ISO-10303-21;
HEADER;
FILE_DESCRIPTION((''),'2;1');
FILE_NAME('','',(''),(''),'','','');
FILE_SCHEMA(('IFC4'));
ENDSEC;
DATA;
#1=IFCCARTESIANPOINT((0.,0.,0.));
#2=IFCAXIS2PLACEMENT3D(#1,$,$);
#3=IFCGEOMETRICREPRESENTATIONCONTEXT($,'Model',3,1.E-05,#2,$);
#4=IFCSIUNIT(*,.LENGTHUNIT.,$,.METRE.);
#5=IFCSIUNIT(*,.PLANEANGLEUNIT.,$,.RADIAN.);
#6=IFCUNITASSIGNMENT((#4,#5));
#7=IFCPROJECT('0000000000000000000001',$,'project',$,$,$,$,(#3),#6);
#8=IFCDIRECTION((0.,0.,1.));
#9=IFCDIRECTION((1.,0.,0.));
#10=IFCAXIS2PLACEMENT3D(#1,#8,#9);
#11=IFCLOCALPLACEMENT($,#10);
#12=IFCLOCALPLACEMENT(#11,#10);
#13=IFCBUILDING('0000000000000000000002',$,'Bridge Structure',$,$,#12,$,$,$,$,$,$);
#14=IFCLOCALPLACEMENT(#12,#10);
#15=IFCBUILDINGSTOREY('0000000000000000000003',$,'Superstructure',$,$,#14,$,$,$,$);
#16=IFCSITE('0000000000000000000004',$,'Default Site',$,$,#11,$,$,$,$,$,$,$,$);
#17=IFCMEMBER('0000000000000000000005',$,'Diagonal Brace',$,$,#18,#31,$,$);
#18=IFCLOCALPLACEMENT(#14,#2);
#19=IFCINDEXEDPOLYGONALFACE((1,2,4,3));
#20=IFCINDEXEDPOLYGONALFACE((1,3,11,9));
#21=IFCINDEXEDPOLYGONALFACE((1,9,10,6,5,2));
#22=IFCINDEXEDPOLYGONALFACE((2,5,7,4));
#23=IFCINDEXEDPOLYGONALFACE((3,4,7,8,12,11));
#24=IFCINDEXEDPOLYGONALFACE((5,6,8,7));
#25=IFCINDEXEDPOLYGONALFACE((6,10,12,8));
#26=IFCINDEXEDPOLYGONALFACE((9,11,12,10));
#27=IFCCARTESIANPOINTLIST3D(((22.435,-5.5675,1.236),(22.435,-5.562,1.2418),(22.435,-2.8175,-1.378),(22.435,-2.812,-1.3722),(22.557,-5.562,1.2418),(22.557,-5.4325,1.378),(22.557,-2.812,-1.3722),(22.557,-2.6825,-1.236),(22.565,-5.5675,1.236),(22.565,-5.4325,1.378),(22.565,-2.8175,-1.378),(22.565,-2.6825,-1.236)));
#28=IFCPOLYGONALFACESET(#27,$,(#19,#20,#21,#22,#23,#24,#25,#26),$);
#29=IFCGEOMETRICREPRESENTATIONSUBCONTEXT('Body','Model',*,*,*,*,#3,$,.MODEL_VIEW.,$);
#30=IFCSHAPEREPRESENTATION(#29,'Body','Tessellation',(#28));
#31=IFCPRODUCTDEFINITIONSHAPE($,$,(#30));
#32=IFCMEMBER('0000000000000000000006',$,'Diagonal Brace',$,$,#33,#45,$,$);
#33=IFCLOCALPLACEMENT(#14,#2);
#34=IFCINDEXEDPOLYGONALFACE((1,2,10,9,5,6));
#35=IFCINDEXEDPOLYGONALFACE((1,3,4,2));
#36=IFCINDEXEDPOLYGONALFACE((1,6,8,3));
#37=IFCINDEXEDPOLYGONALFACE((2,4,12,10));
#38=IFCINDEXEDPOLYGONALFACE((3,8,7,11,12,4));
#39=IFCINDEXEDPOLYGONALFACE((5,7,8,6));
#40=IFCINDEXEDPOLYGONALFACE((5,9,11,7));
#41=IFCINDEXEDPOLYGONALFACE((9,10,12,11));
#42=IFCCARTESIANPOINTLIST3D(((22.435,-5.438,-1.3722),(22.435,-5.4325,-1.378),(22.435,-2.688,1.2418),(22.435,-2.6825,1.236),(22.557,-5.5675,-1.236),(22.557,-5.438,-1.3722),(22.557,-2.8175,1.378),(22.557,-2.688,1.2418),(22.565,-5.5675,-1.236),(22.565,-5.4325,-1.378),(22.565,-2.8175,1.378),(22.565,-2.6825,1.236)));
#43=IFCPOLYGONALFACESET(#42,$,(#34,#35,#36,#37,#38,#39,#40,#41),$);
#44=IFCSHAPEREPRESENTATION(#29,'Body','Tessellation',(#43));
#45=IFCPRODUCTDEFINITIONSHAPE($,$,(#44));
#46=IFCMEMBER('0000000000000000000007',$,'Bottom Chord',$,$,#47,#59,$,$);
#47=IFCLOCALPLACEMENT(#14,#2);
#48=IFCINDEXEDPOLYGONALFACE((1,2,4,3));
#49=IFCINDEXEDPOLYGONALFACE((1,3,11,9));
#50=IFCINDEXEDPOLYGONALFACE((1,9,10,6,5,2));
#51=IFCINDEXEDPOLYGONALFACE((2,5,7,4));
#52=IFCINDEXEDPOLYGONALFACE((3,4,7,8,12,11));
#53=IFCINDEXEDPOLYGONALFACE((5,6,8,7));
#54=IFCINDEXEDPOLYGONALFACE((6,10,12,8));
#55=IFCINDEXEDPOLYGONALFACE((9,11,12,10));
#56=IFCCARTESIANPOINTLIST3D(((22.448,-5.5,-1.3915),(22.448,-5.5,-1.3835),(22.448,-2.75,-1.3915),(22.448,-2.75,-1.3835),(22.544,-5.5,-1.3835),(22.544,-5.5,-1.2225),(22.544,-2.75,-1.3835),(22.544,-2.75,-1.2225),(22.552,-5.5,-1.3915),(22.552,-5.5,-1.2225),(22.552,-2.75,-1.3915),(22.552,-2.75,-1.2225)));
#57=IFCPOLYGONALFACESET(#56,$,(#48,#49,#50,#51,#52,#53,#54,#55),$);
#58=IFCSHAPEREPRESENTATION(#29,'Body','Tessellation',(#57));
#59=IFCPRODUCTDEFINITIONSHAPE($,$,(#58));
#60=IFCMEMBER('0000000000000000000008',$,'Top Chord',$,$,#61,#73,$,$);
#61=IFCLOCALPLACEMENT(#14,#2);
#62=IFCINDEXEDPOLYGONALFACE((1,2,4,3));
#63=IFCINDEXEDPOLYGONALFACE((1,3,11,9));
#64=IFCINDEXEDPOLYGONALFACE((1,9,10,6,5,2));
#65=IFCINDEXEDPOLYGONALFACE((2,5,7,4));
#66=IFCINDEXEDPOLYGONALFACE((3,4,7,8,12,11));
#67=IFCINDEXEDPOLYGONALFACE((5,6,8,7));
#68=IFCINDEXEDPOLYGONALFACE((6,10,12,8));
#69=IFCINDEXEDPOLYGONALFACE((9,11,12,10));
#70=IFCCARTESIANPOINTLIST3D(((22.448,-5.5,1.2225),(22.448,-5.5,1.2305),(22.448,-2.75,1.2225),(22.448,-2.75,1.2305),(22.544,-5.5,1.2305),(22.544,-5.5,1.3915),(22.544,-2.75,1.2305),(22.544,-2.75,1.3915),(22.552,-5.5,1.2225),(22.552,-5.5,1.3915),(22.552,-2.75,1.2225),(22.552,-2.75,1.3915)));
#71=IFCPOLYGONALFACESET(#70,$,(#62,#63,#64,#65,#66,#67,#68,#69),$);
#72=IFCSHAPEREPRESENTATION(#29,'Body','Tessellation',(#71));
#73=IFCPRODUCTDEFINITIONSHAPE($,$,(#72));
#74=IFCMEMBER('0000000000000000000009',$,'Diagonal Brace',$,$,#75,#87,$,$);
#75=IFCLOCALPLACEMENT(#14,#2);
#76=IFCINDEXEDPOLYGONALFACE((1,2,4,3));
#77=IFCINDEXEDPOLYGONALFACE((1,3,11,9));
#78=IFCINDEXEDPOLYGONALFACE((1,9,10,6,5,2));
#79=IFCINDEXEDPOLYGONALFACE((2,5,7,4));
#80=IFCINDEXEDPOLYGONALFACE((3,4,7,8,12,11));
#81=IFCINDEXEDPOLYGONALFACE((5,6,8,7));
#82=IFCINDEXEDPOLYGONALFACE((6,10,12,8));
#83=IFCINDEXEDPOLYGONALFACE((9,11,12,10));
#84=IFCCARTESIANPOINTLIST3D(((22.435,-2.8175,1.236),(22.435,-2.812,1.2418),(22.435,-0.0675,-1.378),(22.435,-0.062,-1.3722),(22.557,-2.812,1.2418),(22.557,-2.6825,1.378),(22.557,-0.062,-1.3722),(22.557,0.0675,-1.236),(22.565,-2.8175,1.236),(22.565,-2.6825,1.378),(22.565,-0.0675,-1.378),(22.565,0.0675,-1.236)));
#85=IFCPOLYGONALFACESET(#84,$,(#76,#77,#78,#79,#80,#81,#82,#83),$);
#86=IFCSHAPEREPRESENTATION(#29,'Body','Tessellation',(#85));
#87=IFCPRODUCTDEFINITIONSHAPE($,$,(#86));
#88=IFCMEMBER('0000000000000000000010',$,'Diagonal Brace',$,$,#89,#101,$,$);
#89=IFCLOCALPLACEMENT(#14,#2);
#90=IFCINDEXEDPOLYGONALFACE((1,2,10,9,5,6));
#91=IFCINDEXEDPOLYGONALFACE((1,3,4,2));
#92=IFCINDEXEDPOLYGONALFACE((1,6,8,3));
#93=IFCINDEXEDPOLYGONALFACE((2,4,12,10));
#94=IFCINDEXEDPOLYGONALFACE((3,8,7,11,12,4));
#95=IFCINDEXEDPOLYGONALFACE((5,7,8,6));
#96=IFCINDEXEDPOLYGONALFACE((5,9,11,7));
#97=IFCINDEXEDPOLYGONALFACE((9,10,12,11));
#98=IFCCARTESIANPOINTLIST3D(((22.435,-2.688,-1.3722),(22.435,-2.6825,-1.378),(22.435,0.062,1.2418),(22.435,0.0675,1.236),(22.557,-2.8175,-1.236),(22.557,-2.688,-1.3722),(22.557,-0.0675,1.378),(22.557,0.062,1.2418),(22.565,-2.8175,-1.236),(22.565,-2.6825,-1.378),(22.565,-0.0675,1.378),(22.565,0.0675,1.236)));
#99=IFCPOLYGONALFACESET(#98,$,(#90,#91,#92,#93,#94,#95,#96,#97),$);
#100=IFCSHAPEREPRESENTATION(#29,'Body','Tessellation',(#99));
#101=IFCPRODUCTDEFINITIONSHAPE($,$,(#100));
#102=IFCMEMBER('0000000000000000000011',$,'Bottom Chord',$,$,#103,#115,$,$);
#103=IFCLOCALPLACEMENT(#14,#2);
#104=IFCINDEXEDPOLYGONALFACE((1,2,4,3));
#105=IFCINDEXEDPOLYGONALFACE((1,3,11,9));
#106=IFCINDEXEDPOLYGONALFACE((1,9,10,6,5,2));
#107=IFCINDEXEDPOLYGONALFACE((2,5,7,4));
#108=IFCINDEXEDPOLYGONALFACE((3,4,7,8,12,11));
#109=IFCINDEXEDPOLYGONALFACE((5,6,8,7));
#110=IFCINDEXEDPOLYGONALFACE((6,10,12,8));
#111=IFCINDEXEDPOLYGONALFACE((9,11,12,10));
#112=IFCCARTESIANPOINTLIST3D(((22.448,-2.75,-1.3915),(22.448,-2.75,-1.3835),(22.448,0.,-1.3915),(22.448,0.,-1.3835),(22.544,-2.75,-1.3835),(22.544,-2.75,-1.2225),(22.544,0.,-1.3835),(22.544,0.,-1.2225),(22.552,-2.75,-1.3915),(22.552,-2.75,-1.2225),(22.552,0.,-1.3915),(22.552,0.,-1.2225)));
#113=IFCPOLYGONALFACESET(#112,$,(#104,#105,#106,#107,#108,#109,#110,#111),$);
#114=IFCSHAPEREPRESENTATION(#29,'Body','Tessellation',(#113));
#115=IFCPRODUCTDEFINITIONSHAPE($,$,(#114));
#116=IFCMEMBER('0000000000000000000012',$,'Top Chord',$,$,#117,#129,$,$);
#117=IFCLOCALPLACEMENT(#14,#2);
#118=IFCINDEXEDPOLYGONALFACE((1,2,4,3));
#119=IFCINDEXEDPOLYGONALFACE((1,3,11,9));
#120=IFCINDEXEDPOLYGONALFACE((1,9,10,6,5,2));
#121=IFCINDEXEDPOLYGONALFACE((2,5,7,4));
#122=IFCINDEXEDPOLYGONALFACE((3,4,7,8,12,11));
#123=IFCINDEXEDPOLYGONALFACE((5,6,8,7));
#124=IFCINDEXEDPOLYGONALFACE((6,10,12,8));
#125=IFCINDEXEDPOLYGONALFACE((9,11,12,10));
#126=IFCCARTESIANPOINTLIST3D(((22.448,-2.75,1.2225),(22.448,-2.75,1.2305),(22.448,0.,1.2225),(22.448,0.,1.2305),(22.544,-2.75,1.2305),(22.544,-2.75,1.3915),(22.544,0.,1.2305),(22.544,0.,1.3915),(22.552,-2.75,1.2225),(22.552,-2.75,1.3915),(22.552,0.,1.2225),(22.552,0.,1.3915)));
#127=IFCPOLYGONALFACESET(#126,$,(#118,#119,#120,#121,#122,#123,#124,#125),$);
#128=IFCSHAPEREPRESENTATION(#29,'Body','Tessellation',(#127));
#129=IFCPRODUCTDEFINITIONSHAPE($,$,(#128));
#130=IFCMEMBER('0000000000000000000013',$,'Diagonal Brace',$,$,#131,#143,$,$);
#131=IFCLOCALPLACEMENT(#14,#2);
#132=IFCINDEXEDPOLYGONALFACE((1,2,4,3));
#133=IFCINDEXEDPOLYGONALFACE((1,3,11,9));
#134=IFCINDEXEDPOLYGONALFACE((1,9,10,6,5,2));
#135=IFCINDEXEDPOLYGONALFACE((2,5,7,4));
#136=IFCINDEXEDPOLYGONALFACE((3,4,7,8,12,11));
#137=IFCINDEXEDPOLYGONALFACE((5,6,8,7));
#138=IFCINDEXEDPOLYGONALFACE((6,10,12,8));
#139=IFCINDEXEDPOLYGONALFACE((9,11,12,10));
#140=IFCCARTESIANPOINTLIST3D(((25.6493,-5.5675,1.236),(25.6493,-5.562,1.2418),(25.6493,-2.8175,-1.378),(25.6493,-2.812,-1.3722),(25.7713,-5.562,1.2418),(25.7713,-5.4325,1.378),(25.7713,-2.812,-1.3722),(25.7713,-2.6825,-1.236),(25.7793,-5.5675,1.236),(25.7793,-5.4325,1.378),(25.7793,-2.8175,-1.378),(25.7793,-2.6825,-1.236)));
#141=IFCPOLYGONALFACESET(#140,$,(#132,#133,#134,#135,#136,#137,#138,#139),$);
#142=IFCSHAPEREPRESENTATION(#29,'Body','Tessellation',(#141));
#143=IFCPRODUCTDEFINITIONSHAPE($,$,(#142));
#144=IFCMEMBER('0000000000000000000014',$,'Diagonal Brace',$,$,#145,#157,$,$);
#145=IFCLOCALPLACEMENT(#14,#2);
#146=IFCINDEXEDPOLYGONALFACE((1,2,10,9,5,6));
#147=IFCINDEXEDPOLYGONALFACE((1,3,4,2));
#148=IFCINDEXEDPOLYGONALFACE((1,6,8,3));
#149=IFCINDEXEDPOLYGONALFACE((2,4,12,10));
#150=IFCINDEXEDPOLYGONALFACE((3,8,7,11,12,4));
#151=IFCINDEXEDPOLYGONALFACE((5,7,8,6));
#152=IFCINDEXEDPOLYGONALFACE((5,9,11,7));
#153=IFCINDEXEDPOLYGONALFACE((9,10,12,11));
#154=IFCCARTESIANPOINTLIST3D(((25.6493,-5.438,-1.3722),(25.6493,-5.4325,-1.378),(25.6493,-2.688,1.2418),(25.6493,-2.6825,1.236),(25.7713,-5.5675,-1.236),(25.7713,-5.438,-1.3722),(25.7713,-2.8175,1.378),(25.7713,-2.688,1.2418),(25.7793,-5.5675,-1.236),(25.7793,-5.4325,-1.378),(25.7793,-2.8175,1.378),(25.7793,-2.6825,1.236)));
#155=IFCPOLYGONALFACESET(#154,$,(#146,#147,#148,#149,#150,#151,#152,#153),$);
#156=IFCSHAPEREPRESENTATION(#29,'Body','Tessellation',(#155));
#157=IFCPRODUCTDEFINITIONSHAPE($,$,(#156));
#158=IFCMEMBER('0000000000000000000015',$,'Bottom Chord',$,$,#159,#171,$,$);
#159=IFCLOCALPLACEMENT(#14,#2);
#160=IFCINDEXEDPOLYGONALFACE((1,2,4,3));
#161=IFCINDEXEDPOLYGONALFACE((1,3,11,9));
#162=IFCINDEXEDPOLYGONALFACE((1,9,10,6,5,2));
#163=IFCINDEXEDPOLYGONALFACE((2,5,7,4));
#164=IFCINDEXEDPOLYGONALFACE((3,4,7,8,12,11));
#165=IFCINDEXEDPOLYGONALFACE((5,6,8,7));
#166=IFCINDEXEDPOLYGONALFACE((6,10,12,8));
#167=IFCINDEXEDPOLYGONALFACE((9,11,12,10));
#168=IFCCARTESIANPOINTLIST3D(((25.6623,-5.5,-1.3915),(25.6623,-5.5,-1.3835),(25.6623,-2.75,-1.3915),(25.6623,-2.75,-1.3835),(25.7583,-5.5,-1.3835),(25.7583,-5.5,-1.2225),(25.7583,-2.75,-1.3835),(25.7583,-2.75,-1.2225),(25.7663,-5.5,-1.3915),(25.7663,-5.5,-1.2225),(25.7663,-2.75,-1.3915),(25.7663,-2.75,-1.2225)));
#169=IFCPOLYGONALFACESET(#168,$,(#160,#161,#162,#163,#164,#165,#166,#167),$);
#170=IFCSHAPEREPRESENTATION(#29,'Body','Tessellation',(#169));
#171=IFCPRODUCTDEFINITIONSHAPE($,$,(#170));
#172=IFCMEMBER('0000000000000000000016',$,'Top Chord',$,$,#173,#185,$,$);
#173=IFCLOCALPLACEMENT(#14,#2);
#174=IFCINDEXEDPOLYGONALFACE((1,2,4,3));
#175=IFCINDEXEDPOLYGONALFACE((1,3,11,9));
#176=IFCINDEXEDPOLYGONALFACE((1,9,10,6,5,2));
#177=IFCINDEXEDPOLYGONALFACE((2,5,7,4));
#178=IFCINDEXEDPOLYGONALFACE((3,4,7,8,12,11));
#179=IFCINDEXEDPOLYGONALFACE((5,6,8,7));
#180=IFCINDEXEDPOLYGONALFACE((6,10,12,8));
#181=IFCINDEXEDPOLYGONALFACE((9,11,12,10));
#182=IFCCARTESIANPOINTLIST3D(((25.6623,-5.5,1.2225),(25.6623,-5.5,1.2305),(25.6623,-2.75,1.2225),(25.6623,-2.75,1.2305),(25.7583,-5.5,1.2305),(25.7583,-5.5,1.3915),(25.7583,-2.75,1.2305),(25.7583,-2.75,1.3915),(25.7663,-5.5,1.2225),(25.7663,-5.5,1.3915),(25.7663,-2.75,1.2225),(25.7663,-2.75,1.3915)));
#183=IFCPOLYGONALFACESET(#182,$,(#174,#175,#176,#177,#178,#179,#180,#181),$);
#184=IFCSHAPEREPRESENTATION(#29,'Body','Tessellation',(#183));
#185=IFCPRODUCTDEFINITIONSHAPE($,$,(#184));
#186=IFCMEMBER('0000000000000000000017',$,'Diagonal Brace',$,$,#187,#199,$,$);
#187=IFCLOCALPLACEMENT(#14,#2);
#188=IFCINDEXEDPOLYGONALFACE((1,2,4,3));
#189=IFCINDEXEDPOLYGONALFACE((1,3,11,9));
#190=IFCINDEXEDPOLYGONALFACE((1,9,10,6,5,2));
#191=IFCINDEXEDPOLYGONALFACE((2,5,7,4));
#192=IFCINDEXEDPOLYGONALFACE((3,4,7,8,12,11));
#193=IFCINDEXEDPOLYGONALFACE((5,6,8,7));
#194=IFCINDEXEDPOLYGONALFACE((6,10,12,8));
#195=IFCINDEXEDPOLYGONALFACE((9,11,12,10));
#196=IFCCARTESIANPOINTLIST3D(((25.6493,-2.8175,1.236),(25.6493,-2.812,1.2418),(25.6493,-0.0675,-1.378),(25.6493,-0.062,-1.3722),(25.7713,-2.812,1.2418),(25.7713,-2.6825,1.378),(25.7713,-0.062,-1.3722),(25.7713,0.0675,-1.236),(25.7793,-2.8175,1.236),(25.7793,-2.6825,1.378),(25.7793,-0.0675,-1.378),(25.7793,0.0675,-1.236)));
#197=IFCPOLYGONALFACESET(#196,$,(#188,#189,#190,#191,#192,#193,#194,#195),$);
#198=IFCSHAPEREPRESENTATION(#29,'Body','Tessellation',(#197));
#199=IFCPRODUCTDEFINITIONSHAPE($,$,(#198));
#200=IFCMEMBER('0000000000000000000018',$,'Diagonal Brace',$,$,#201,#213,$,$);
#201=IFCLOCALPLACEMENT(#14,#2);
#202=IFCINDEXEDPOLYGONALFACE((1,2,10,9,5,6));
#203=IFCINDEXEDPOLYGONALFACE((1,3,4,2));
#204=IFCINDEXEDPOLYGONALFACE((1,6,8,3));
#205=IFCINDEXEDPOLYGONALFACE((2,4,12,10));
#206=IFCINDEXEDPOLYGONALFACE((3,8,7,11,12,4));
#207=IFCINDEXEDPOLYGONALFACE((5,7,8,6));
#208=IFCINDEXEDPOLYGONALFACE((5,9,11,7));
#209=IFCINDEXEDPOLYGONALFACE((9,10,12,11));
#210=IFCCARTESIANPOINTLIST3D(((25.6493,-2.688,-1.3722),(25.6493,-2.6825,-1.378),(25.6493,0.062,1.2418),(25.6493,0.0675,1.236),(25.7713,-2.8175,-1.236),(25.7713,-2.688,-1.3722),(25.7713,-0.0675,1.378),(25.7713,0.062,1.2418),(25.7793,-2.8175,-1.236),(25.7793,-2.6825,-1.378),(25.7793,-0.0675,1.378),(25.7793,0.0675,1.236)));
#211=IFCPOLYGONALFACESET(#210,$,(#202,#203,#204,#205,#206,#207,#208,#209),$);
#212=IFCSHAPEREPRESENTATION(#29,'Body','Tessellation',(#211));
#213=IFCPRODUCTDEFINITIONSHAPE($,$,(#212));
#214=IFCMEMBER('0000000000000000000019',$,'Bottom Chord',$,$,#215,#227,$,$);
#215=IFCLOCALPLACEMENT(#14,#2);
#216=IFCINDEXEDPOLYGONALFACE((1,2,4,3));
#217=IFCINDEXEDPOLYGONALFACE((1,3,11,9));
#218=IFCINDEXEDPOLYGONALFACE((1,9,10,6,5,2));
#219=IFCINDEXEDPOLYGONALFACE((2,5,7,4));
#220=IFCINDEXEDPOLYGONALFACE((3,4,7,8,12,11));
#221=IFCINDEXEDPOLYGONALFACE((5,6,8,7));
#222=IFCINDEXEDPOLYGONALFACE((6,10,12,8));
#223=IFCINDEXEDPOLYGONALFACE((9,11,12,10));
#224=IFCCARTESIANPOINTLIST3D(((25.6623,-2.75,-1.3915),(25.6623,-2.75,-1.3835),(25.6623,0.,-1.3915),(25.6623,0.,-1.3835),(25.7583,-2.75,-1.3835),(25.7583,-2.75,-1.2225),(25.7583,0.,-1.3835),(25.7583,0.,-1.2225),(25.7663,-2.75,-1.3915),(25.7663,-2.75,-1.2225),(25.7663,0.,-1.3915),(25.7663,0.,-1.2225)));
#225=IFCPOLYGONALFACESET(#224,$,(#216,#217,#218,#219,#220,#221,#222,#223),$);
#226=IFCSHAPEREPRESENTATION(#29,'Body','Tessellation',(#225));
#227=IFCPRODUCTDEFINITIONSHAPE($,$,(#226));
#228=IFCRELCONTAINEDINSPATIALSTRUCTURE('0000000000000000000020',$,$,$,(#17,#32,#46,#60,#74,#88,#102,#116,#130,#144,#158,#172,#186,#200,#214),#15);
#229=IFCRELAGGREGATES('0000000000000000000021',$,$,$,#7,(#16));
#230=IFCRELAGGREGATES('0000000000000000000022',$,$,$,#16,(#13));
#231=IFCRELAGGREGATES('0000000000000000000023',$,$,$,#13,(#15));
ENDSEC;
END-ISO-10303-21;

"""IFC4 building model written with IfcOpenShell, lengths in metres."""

from ifc_helpers import new_model, si_unit, frame, origin, origin_with_axes, origin_2d_with_axis, place, context, subcontext, project, spatial, l_section, extrude, element, save


model = new_model("IFC4")

# Units and contexts
model_context = context("Model", 3, precision=1e-05, world=origin())
body_context = subcontext(model_context, "Body", "Model", "MODEL_VIEW")
ifc_project = project(units=[si_unit("LENGTHUNIT", "METRE"), si_unit("PLANEANGLEUNIT", "RADIAN")], contexts=[model_context])

# Site, building, storey
site_placement = place(None, origin_with_axes())
site = spatial("IfcSite", under=ifc_project, at=site_placement, Name="Default Site")
building_placement = place(site_placement, origin_with_axes())
building = spatial("IfcBuilding", under=site, at=building_placement, Name="Bridge Structure")
storey_placement = place(building_placement, origin_with_axes())
storey = spatial("IfcBuildingStorey", under=building, at=storey_placement, Name="Superstructure")

# Members
for number, where, z_axis, x_axis, name in (
    (1, (22.5, -5.5, 1.307), (0.0, 0.724802, -0.688957), (-1.0, 0.0, 0.0), "Diagonal Brace"),
    (2, (22.5, -5.5, -1.307), (0.0, 0.724802, 0.688957), (-1.0, 0.0, 0.0), "Diagonal Brace"),
):
    element("IfcMember", number, at=place(storey_placement, frame(where, z_axis=z_axis, x_axis=x_axis)), inside=storey, Name=name, context=body_context, shape_type="SweptSolid", body=[
        extrude(l_section(Depth=0.196, Width=0.13, Thickness=0.008, at=origin_2d_with_axis()), origin_with_axes(), (0.0, 0.0, 1.0), 3.7941),
    ])
for number, where, z_axis, x_axis, name in (
    (3, (22.5, -5.5, -1.307), (0.0, 1.0, 0.0), (-1.0, 0.0, 0.0), "Bottom Chord"),
    (4, (22.5, -5.5, 1.307), (0.0, 1.0, 0.0), (-1.0, 0.0, 0.0), "Top Chord"),
):
    element("IfcMember", number, at=place(storey_placement, frame(where, z_axis=z_axis, x_axis=x_axis)), inside=storey, Name=name, context=body_context, shape_type="SweptSolid", body=[
        extrude(l_section(Depth=0.169, Width=0.104, Thickness=0.008, at=origin_2d_with_axis()), origin_with_axes(), (0.0, 0.0, 1.0), 2.75),
    ])
for number, where, z_axis, x_axis, name in (
    (5, (22.5, -2.75, 1.307), (0.0, 0.724802, -0.688957), (-1.0, 0.0, 0.0), "Diagonal Brace"),
    (6, (22.5, -2.75, -1.307), (0.0, 0.724802, 0.688957), (-1.0, 0.0, 0.0), "Diagonal Brace"),
):
    element("IfcMember", number, at=place(storey_placement, frame(where, z_axis=z_axis, x_axis=x_axis)), inside=storey, Name=name, context=body_context, shape_type="SweptSolid", body=[
        extrude(l_section(Depth=0.196, Width=0.13, Thickness=0.008, at=origin_2d_with_axis()), origin_with_axes(), (0.0, 0.0, 1.0), 3.7941),
    ])
for number, where, z_axis, x_axis, name in (
    (7, (22.5, -2.75, -1.307), (0.0, 1.0, 0.0), (-1.0, 0.0, 0.0), "Bottom Chord"),
    (8, (22.5, -2.75, 1.307), (0.0, 1.0, 0.0), (-1.0, 0.0, 0.0), "Top Chord"),
):
    element("IfcMember", number, at=place(storey_placement, frame(where, z_axis=z_axis, x_axis=x_axis)), inside=storey, Name=name, context=body_context, shape_type="SweptSolid", body=[
        extrude(l_section(Depth=0.169, Width=0.104, Thickness=0.008, at=origin_2d_with_axis()), origin_with_axes(), (0.0, 0.0, 1.0), 2.75),
    ])
for number, where, z_axis, x_axis, name in (
    (9, (25.7143, -5.5, 1.307), (0.0, 0.724802, -0.688957), (-1.0, 0.0, 0.0), "Diagonal Brace"),
    (10, (25.7143, -5.5, -1.307), (0.0, 0.724802, 0.688957), (-1.0, 0.0, 0.0), "Diagonal Brace"),
):
    element("IfcMember", number, at=place(storey_placement, frame(where, z_axis=z_axis, x_axis=x_axis)), inside=storey, Name=name, context=body_context, shape_type="SweptSolid", body=[
        extrude(l_section(Depth=0.196, Width=0.13, Thickness=0.008, at=origin_2d_with_axis()), origin_with_axes(), (0.0, 0.0, 1.0), 3.7941),
    ])
for number, where, z_axis, x_axis, name in (
    (11, (25.7143, -5.5, -1.307), (0.0, 1.0, 0.0), (-1.0, 0.0, 0.0), "Bottom Chord"),
    (12, (25.7143, -5.5, 1.307), (0.0, 1.0, 0.0), (-1.0, 0.0, 0.0), "Top Chord"),
):
    element("IfcMember", number, at=place(storey_placement, frame(where, z_axis=z_axis, x_axis=x_axis)), inside=storey, Name=name, context=body_context, shape_type="SweptSolid", body=[
        extrude(l_section(Depth=0.169, Width=0.104, Thickness=0.008, at=origin_2d_with_axis()), origin_with_axes(), (0.0, 0.0, 1.0), 2.75),
    ])
for number, where, z_axis, x_axis, name in (
    (13, (25.7143, -2.75, 1.307), (0.0, 0.724802, -0.688957), (-1.0, 0.0, 0.0), "Diagonal Brace"),
    (14, (25.7143, -2.75, -1.307), (0.0, 0.724802, 0.688957), (-1.0, 0.0, 0.0), "Diagonal Brace"),
):
    element("IfcMember", number, at=place(storey_placement, frame(where, z_axis=z_axis, x_axis=x_axis)), inside=storey, Name=name, context=body_context, shape_type="SweptSolid", body=[
        extrude(l_section(Depth=0.196, Width=0.13, Thickness=0.008, at=origin_2d_with_axis()), origin_with_axes(), (0.0, 0.0, 1.0), 3.7941),
    ])
for number, where, z_axis, x_axis, name in (
    (15, (25.7143, -2.75, -1.307), (0.0, 1.0, 0.0), (-1.0, 0.0, 0.0), "Bottom Chord"),
):
    element("IfcMember", number, at=place(storey_placement, frame(where, z_axis=z_axis, x_axis=x_axis)), inside=storey, Name=name, context=body_context, shape_type="SweptSolid", body=[
        extrude(l_section(Depth=0.169, Width=0.104, Thickness=0.008, at=origin_2d_with_axis()), origin_with_axes(), (0.0, 0.0, 1.0), 2.75),
    ])

save(model, "model.ifc")
